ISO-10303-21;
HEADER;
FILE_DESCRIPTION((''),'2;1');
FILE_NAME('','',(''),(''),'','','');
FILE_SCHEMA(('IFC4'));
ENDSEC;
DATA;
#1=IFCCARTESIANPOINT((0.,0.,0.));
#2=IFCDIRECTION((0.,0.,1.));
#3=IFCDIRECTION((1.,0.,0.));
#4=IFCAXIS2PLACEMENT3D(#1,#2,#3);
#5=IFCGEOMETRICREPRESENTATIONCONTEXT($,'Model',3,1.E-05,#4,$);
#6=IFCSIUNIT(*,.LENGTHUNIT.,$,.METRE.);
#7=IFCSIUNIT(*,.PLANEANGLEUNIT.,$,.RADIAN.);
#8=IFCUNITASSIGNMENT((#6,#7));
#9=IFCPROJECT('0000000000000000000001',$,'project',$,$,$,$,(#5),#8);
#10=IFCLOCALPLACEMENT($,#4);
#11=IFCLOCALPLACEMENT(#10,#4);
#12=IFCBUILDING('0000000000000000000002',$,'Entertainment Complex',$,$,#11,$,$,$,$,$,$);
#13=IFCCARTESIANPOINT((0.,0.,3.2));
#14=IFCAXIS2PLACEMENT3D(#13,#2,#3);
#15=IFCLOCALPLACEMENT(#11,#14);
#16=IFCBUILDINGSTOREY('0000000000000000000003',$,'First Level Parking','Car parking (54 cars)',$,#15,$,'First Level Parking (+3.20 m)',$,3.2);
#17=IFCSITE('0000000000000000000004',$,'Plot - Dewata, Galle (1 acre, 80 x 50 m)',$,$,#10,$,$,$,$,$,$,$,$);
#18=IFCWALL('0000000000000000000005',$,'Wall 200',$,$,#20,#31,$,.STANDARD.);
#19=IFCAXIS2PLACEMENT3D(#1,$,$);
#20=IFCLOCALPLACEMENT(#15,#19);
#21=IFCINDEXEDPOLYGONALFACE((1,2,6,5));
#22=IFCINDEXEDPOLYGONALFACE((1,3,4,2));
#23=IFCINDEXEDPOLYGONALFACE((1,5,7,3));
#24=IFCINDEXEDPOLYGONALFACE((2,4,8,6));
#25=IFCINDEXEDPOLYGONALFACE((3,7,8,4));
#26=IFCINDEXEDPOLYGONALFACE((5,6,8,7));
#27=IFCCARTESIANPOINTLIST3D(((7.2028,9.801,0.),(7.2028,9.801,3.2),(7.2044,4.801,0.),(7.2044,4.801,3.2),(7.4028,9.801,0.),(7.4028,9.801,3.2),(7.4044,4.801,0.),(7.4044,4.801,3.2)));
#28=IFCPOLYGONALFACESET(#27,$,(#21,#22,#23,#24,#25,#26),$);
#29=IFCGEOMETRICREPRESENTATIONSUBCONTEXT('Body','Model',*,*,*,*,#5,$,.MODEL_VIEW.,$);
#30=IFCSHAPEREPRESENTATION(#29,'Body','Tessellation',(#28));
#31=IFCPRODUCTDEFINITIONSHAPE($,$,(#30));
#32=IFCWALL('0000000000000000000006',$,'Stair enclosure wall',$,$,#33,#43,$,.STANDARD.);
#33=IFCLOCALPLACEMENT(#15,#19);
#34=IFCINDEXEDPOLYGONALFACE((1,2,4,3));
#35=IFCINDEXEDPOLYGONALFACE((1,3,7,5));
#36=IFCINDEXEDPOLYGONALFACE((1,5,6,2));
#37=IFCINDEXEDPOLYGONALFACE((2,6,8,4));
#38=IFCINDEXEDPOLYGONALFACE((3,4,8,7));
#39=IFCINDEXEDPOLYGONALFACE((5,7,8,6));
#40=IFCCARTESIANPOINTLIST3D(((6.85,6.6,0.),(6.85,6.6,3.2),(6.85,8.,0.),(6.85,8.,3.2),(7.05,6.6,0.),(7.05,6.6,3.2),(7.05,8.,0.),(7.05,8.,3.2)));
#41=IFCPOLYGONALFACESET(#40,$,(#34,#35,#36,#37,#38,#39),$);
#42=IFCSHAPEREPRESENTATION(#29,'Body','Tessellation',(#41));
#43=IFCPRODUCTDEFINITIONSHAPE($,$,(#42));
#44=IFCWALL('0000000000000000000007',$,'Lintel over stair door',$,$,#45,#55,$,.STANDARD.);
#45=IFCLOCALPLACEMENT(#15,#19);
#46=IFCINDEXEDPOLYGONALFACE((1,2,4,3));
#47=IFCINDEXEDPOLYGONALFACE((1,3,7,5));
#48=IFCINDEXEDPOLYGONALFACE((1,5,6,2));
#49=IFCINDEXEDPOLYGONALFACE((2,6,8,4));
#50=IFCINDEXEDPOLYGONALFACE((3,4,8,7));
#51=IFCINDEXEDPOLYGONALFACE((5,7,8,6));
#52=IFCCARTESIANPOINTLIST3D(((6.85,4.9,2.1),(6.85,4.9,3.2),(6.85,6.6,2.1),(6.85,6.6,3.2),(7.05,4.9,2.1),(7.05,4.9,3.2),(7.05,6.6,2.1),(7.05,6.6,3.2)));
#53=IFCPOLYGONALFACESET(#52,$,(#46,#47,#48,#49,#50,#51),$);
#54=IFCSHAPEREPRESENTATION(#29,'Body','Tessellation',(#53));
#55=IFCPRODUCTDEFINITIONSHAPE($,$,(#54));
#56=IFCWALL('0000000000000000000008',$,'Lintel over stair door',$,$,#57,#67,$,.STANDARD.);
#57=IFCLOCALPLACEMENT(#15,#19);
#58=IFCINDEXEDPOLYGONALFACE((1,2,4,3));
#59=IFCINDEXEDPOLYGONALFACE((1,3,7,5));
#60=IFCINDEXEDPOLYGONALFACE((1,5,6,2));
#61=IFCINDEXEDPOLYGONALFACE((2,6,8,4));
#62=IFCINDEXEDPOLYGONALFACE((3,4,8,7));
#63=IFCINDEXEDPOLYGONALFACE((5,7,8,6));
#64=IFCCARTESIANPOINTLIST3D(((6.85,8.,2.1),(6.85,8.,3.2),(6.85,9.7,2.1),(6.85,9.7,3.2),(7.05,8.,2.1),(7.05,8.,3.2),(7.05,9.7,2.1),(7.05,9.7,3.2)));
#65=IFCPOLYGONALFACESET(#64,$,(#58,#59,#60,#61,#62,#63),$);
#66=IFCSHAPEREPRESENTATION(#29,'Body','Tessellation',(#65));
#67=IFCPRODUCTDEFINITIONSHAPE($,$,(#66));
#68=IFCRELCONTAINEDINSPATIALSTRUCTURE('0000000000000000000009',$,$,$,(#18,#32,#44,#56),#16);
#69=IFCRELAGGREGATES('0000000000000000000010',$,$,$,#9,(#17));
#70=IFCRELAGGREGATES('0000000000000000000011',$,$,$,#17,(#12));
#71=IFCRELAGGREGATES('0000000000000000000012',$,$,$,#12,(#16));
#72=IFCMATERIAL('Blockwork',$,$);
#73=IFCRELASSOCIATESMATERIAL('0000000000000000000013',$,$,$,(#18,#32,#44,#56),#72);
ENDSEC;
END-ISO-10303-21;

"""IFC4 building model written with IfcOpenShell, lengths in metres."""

from ifc_helpers import new_model, si_unit, frame, origin_with_axes, place, context, subcontext, project, spatial, polyline, outline, extrude, material, element, save


model = new_model("IFC4")

# Units and contexts
model_context = context("Model", 3, precision=1e-05, world=origin_with_axes())
body_context = subcontext(model_context, "Body", "Model", "MODEL_VIEW")
ifc_project = project(units=[si_unit("LENGTHUNIT", "METRE"), si_unit("PLANEANGLEUNIT", "RADIAN")], contexts=[model_context])

# Site, building, storey
site_placement = place(None, origin_with_axes())
site = spatial("IfcSite", under=ifc_project, at=site_placement, Name="Plot - Dewata, Galle (1 acre, 80 x 50 m)")
building_placement = place(site_placement, origin_with_axes())
building = spatial("IfcBuilding", under=site, at=building_placement, Name="Entertainment Complex")
storey_placement = place(building_placement, frame((0.0, 0.0, 3.2), z_axis=(0.0, 0.0, 1.0), x_axis=(1.0, 0.0, 0.0)))
storey = spatial("IfcBuildingStorey", under=building, at=storey_placement, Name="First Level Parking", Description="Car parking (54 cars)", LongName="First Level Parking (+3.20 m)", Elevation=3.2)

# Walls
ifc_material_1 = material(Name="Blockwork")
wall_1_placement = place(storey_placement, frame((7.3044, 4.801, 0.0), z_axis=(0.0, 0.0, 1.0), x_axis=(-0.00032, 1.0, 0.0)))
element("IfcWall", 1, at=wall_1_placement, inside=storey, material=ifc_material_1, Name="Wall 200", PredefinedType="STANDARD", context=body_context, shape_type="SweptSolid", body=[
    extrude(outline(polyline([(0.0, -0.1), (5.0, -0.1), (5.0, 0.1), (0.0, 0.1), (0.0, -0.1)])), origin_with_axes(), (0.0, 0.0, 1.0), 3.2),
])
wall_2_placement = place(storey_placement, frame((6.95, 6.6, 0.0), z_axis=(0.0, 0.0, 1.0), x_axis=(0.0, 1.0, 0.0)))
element("IfcWall", 2, at=wall_2_placement, inside=storey, material=ifc_material_1, Name="Stair enclosure wall", PredefinedType="STANDARD", context=body_context, shape_type="SweptSolid", body=[
    extrude(outline(polyline([(0.0, -0.1), (1.4, -0.1), (1.4, 0.1), (0.0, 0.1), (0.0, -0.1)])), origin_with_axes(), (0.0, 0.0, 1.0), 3.2),
])
for number, where, z_axis, x_axis, name in (
    (3, (6.95, 4.9, 2.1), (0.0, 0.0, 1.0), (0.0, 1.0, 0.0), "Lintel over stair door"),
    (4, (6.95, 8.0, 2.1), (0.0, 0.0, 1.0), (0.0, 1.0, 0.0), "Lintel over stair door"),
):
    element("IfcWall", number, at=place(storey_placement, frame(where, z_axis=z_axis, x_axis=x_axis)), inside=storey, material=ifc_material_1, Name=name, PredefinedType="STANDARD", context=body_context, shape_type="SweptSolid", body=[
        extrude(outline(polyline([(0.0, -0.1), (1.7, -0.1), (1.7, 0.1), (0.0, 0.1), (0.0, -0.1)])), origin_with_axes(), (0.0, 0.0, 1.0), 1.1),
    ])

save(model, "model.ifc")
